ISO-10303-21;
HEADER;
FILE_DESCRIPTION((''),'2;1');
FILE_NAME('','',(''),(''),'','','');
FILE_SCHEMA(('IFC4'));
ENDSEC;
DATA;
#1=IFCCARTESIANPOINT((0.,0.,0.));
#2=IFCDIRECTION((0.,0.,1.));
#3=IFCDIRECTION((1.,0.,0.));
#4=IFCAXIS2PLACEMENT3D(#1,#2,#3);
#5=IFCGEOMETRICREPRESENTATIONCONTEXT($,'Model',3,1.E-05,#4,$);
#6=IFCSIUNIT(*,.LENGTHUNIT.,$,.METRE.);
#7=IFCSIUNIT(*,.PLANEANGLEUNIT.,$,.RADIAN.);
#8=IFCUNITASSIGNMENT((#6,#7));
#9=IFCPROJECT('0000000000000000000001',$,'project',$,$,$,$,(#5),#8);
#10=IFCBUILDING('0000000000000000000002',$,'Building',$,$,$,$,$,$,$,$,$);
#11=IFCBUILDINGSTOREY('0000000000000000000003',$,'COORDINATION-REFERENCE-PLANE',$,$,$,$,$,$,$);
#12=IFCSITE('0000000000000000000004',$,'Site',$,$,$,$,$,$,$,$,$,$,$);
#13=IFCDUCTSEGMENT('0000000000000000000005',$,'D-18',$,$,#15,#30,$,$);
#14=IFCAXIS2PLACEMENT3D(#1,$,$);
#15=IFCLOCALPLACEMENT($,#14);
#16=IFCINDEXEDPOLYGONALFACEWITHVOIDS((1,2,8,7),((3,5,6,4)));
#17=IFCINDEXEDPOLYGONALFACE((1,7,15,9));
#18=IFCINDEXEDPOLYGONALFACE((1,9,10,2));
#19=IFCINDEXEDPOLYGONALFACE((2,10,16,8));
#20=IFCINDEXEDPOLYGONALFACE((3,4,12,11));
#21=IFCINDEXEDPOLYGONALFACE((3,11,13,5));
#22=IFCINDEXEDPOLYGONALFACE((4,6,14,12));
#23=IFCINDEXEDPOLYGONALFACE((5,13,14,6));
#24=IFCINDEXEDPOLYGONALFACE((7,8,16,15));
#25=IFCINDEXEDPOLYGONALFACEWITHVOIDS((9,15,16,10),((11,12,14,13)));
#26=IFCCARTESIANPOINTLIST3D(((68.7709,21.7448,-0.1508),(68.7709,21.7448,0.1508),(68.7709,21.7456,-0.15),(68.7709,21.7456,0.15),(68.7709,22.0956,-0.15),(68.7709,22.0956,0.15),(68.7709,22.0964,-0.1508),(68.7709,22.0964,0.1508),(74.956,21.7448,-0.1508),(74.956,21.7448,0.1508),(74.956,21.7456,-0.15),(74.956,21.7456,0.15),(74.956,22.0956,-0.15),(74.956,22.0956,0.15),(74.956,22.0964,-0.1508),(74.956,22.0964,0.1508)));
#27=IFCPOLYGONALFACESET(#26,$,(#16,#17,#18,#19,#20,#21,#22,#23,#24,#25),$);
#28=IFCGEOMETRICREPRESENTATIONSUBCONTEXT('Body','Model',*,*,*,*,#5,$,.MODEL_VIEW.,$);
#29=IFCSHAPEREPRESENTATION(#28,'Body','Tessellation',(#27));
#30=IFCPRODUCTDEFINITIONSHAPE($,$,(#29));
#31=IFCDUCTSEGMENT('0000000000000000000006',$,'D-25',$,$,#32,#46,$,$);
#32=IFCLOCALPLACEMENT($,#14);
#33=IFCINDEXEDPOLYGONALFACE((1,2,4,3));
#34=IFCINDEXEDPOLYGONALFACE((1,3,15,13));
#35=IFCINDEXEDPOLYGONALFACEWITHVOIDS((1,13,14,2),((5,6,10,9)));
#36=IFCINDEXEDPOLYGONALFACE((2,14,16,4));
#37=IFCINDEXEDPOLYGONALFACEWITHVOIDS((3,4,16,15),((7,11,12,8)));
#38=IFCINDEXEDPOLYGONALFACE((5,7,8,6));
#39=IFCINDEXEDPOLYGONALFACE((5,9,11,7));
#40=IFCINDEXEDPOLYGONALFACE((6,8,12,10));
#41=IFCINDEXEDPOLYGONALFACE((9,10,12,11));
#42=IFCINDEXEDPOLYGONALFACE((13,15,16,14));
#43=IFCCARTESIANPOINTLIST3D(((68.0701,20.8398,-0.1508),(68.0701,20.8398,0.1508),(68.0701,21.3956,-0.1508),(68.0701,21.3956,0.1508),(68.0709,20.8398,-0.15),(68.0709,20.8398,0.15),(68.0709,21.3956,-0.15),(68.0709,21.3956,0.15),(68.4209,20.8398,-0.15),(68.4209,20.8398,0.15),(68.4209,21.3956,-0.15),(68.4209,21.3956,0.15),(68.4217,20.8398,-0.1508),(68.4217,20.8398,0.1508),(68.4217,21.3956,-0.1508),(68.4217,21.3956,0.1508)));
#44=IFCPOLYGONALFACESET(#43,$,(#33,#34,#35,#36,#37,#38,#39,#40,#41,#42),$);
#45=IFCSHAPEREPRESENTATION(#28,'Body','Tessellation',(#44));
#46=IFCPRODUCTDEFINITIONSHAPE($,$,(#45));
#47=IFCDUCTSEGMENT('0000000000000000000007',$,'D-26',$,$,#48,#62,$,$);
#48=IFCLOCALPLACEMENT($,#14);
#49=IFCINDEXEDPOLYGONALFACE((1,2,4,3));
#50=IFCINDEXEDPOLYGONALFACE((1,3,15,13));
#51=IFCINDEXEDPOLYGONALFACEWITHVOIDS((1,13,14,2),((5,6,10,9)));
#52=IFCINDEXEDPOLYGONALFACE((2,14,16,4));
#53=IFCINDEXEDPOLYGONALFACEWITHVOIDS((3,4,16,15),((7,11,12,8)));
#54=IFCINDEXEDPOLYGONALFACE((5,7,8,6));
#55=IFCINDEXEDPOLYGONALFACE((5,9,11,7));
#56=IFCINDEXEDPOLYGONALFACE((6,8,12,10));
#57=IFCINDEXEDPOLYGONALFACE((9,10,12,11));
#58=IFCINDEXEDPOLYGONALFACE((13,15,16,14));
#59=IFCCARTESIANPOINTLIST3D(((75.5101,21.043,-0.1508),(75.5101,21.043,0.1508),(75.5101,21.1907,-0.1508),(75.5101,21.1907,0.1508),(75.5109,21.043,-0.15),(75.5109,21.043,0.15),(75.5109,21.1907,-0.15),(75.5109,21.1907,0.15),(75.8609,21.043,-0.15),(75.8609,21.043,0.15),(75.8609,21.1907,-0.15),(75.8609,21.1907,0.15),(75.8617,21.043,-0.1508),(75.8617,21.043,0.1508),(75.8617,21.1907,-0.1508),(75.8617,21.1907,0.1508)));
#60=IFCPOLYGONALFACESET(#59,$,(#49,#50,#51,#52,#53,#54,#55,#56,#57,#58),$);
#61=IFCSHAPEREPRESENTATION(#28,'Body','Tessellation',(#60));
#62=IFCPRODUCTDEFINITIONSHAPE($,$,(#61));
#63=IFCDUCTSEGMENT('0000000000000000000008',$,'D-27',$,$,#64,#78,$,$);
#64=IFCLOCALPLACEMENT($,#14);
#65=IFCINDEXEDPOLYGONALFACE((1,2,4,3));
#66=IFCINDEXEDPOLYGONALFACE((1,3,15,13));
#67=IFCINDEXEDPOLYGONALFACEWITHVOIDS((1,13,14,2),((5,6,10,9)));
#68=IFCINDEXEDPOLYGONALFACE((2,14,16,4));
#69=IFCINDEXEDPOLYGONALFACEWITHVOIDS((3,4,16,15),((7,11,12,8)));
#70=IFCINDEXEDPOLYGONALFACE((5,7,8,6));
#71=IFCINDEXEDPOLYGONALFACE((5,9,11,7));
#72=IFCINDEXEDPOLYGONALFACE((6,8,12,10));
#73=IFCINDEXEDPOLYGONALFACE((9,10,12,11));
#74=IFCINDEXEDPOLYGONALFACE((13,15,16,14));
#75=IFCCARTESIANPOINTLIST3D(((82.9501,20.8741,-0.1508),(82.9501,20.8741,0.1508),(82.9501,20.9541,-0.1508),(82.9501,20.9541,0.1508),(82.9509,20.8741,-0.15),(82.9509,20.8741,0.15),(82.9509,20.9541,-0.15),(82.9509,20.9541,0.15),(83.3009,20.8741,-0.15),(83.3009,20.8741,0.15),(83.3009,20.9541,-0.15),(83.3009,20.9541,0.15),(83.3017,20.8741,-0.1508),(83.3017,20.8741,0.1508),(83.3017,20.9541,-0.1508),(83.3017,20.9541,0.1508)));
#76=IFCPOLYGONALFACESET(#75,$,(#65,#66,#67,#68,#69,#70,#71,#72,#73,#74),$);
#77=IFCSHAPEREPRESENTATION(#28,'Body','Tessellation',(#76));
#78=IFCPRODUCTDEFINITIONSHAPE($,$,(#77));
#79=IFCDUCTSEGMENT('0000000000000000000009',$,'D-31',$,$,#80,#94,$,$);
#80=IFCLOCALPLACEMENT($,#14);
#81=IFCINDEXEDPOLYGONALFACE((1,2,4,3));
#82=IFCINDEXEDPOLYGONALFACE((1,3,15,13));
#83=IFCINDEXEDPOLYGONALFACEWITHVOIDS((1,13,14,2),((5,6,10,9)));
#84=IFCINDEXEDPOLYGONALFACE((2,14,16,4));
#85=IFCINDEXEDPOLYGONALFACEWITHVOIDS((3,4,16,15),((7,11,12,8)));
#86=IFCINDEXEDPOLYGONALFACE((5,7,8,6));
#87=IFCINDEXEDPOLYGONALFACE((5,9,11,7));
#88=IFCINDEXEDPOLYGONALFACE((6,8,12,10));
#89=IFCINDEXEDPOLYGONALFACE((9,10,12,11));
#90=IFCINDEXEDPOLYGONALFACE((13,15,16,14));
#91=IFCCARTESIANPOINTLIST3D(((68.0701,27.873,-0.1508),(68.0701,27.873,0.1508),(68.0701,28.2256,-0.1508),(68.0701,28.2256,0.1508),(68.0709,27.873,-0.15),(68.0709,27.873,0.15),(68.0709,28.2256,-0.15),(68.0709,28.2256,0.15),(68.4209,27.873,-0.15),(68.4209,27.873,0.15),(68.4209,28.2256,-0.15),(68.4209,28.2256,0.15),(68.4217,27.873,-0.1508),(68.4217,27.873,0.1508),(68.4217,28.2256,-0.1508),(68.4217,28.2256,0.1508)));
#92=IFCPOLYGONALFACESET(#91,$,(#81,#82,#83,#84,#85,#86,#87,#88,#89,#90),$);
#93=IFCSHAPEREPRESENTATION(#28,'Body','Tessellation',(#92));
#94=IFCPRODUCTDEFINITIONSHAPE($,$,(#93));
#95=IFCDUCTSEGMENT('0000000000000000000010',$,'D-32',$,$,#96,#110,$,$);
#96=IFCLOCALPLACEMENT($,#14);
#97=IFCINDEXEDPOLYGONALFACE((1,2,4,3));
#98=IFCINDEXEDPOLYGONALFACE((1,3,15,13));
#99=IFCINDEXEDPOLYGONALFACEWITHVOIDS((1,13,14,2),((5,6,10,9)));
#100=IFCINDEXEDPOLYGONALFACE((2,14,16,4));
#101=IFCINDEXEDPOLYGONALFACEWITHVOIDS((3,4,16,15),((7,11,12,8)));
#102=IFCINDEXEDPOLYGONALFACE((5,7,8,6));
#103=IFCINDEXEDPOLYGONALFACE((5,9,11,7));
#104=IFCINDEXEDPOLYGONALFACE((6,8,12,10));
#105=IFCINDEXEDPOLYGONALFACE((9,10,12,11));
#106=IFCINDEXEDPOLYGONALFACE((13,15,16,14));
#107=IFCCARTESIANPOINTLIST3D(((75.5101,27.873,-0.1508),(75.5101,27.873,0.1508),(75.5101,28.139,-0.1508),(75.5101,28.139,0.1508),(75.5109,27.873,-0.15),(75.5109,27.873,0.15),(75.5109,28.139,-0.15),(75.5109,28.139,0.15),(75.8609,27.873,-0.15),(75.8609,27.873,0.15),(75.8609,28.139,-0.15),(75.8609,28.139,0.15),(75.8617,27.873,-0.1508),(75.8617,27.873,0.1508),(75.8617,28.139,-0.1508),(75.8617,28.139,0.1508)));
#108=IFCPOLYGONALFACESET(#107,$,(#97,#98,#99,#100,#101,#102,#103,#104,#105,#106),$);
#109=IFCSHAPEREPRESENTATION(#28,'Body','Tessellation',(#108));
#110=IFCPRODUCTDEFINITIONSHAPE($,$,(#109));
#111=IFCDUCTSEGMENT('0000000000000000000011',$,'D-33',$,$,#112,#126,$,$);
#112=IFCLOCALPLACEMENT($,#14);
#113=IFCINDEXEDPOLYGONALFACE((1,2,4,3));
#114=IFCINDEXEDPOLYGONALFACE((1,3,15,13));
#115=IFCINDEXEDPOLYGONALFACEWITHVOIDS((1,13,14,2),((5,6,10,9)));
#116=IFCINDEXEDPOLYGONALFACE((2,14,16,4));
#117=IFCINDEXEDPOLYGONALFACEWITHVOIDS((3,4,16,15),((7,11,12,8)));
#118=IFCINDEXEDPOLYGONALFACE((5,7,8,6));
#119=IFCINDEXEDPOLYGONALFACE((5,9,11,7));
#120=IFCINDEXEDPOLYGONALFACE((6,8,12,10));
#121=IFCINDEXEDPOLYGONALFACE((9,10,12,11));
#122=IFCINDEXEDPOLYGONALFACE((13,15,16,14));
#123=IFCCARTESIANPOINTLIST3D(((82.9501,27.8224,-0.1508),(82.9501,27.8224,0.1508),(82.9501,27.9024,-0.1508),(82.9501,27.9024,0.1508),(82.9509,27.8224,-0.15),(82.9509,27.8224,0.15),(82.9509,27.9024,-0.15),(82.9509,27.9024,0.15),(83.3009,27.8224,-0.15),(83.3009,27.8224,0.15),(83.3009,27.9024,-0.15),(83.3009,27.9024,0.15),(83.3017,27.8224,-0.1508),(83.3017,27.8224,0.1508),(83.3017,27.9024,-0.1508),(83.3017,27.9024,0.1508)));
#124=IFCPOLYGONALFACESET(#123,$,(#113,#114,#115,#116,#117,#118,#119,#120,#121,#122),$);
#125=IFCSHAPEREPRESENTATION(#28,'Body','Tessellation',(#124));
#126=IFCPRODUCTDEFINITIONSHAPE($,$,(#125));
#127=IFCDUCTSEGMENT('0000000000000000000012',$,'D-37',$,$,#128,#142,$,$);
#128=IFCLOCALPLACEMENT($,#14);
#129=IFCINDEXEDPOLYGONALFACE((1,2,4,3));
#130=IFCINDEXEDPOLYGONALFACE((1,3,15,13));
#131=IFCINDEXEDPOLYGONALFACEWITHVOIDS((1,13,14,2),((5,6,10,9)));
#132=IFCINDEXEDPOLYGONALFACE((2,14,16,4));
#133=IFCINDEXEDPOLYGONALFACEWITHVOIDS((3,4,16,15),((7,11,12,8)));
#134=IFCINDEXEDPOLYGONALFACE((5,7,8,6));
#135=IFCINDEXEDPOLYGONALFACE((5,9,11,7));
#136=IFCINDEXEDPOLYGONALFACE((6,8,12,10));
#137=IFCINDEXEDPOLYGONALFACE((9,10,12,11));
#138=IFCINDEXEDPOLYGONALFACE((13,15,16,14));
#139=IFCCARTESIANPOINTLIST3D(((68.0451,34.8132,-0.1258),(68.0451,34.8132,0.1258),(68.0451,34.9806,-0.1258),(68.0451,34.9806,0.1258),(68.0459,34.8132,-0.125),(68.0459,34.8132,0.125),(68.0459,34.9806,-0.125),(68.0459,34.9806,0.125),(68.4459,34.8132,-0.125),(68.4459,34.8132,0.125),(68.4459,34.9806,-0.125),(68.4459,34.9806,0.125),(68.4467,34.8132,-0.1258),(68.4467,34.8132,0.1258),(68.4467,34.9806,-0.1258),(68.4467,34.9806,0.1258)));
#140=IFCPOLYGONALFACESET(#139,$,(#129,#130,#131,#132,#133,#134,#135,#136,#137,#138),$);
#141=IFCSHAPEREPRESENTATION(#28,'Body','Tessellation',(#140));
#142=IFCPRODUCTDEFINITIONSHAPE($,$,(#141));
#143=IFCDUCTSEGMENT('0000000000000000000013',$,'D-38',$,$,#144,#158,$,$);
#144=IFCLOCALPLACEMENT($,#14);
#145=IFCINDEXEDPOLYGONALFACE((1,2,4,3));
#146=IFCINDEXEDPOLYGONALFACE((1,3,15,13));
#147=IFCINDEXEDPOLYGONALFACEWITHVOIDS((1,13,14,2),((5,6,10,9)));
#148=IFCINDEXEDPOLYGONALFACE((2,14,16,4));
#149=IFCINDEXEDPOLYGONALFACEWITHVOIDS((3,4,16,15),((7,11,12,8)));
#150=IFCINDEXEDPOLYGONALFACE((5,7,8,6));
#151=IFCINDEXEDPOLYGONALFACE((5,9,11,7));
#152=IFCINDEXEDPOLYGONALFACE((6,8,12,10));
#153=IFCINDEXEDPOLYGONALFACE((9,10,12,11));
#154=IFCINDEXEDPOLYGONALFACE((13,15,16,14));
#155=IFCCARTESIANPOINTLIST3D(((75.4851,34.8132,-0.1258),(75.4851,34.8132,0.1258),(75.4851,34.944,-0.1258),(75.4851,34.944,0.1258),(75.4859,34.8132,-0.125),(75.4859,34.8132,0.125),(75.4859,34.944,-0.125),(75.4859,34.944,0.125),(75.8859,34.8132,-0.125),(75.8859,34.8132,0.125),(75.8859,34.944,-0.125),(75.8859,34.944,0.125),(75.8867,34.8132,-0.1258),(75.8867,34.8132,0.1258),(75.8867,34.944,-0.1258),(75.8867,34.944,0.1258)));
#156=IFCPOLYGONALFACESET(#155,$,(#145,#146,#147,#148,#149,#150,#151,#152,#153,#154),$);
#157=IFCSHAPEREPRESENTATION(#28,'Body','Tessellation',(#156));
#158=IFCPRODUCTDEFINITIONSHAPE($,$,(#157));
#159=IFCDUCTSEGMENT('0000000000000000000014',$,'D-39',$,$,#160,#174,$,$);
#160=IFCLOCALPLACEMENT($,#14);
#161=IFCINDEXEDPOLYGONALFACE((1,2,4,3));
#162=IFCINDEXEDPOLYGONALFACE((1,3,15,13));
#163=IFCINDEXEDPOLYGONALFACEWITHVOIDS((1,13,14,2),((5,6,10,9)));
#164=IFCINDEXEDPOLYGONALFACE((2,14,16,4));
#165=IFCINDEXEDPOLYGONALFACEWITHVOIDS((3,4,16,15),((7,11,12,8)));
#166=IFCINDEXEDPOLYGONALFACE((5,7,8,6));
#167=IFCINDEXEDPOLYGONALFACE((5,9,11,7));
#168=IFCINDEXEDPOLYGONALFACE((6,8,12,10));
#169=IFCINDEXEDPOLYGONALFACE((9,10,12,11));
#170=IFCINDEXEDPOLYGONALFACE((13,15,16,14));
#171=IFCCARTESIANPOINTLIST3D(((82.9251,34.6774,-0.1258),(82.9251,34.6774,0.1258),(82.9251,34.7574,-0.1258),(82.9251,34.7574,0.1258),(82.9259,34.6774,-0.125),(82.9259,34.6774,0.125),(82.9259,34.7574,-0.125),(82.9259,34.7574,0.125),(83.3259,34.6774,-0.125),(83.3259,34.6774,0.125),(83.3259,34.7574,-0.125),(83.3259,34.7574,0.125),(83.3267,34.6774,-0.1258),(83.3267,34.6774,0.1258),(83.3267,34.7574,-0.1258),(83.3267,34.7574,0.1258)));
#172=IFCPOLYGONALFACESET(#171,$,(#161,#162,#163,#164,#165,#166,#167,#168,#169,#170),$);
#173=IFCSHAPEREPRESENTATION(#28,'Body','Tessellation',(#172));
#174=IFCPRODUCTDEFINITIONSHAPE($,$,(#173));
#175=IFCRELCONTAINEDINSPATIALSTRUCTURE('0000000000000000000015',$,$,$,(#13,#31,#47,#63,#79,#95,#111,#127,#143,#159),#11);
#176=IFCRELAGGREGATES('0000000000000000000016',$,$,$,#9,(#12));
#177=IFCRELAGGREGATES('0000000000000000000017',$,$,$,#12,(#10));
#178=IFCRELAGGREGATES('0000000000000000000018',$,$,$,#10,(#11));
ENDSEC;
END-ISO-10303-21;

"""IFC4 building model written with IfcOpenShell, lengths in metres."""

from ifc_helpers import new_model, si_unit, frame, origin, origin_with_axes, place, context, subcontext, project, spatial, hollow_rectangle, extrude, element, save


model = new_model("IFC4")

# Units and contexts
model_context = context("Model", 3, precision=1e-05, world=origin_with_axes())
body_context = subcontext(model_context, "Body", "Model", "MODEL_VIEW")
ifc_project = project(units=[si_unit("LENGTHUNIT", "METRE"), si_unit("PLANEANGLEUNIT", "RADIAN")], contexts=[model_context])

# Site, building, storey
site = spatial("IfcSite", under=ifc_project, Name="Site")
building = spatial("IfcBuilding", under=site, Name="Building")
storey = spatial("IfcBuildingStorey", under=building, Name="COORDINATION-REFERENCE-PLANE")

# Duct segments
duct_segment_1_placement = place(None, frame((68.7709, 21.9206, 0.0), z_axis=(1.0, 0.0, 0.0), x_axis=(0.0, 1.0, 0.0)))
element("IfcDuctSegment", 1, at=duct_segment_1_placement, inside=storey, Name="D-18", context=body_context, shape_type="SweptSolid", body=[
    extrude(hollow_rectangle(XDim=0.3516, YDim=0.3016, WallThickness=0.0008), origin(), (0.0, 0.0, 1.0), 6.1851),
])
duct_segment_2_placement = place(None, frame((68.2459, 20.8398, 0.0), z_axis=(0.0, 1.0, 0.0), x_axis=(1.0, 0.0, 0.0)))
element("IfcDuctSegment", 2, at=duct_segment_2_placement, inside=storey, Name="D-25", context=body_context, shape_type="SweptSolid", body=[
    extrude(hollow_rectangle(XDim=0.3516, YDim=0.3016, WallThickness=0.0008), origin(), (0.0, 0.0, 1.0), 0.5558),
])
duct_segment_3_placement = place(None, frame((75.6859, 21.043, 0.0), z_axis=(0.0, 1.0, 0.0), x_axis=(1.0, 0.0, 0.0)))
element("IfcDuctSegment", 3, at=duct_segment_3_placement, inside=storey, Name="D-26", context=body_context, shape_type="SweptSolid", body=[
    extrude(hollow_rectangle(XDim=0.3516, YDim=0.3016, WallThickness=0.0008), origin(), (0.0, 0.0, 1.0), 0.1477),
])
duct_segment_4_placement = place(None, frame((83.1259, 20.8741, 0.0), z_axis=(0.0, 1.0, 0.0), x_axis=(1.0, 0.0, 0.0)))
element("IfcDuctSegment", 4, at=duct_segment_4_placement, inside=storey, Name="D-27", context=body_context, shape_type="SweptSolid", body=[
    extrude(hollow_rectangle(XDim=0.3516, YDim=0.3016, WallThickness=0.0008), origin(), (0.0, 0.0, 1.0), 0.08),
])
duct_segment_5_placement = place(None, frame((68.2459, 27.873, 0.0), z_axis=(0.0, 1.0, 0.0), x_axis=(1.0, 0.0, 0.0)))
element("IfcDuctSegment", 5, at=duct_segment_5_placement, inside=storey, Name="D-31", context=body_context, shape_type="SweptSolid", body=[
    extrude(hollow_rectangle(XDim=0.3516, YDim=0.3016, WallThickness=0.0008), origin(), (0.0, 0.0, 1.0), 0.3526),
])
duct_segment_6_placement = place(None, frame((75.6859, 27.873, 0.0), z_axis=(0.0, 1.0, 0.0), x_axis=(1.0, 0.0, 0.0)))
element("IfcDuctSegment", 6, at=duct_segment_6_placement, inside=storey, Name="D-32", context=body_context, shape_type="SweptSolid", body=[
    extrude(hollow_rectangle(XDim=0.3516, YDim=0.3016, WallThickness=0.0008), origin(), (0.0, 0.0, 1.0), 0.266),
])
duct_segment_7_placement = place(None, frame((83.1259, 27.8224, 0.0), z_axis=(0.0, 1.0, 0.0), x_axis=(1.0, 0.0, 0.0)))
element("IfcDuctSegment", 7, at=duct_segment_7_placement, inside=storey, Name="D-33", context=body_context, shape_type="SweptSolid", body=[
    extrude(hollow_rectangle(XDim=0.3516, YDim=0.3016, WallThickness=0.0008), origin(), (0.0, 0.0, 1.0), 0.08),
])
duct_segment_8_placement = place(None, frame((68.2459, 34.8132, 0.0), z_axis=(0.0, 1.0, 0.0), x_axis=(1.0, 0.0, 0.0)))
element("IfcDuctSegment", 8, at=duct_segment_8_placement, inside=storey, Name="D-37", context=body_context, shape_type="SweptSolid", body=[
    extrude(hollow_rectangle(XDim=0.4016, YDim=0.2516, WallThickness=0.0008), origin(), (0.0, 0.0, 1.0), 0.1673),
])
duct_segment_9_placement = place(None, frame((75.6859, 34.8132, 0.0), z_axis=(0.0, 1.0, 0.0), x_axis=(1.0, 0.0, 0.0)))
element("IfcDuctSegment", 9, at=duct_segment_9_placement, inside=storey, Name="D-38", context=body_context, shape_type="SweptSolid", body=[
    extrude(hollow_rectangle(XDim=0.4016, YDim=0.2516, WallThickness=0.0008), origin(), (0.0, 0.0, 1.0), 0.1307),
])
duct_segment_10_placement = place(None, frame((83.1259, 34.6774, 0.0), z_axis=(0.0, 1.0, 0.0), x_axis=(1.0, 0.0, 0.0)))
element("IfcDuctSegment", 10, at=duct_segment_10_placement, inside=storey, Name="D-39", context=body_context, shape_type="SweptSolid", body=[
    extrude(hollow_rectangle(XDim=0.4016, YDim=0.2516, WallThickness=0.0008), origin(), (0.0, 0.0, 1.0), 0.08),
])

save(model, "model.ifc")
